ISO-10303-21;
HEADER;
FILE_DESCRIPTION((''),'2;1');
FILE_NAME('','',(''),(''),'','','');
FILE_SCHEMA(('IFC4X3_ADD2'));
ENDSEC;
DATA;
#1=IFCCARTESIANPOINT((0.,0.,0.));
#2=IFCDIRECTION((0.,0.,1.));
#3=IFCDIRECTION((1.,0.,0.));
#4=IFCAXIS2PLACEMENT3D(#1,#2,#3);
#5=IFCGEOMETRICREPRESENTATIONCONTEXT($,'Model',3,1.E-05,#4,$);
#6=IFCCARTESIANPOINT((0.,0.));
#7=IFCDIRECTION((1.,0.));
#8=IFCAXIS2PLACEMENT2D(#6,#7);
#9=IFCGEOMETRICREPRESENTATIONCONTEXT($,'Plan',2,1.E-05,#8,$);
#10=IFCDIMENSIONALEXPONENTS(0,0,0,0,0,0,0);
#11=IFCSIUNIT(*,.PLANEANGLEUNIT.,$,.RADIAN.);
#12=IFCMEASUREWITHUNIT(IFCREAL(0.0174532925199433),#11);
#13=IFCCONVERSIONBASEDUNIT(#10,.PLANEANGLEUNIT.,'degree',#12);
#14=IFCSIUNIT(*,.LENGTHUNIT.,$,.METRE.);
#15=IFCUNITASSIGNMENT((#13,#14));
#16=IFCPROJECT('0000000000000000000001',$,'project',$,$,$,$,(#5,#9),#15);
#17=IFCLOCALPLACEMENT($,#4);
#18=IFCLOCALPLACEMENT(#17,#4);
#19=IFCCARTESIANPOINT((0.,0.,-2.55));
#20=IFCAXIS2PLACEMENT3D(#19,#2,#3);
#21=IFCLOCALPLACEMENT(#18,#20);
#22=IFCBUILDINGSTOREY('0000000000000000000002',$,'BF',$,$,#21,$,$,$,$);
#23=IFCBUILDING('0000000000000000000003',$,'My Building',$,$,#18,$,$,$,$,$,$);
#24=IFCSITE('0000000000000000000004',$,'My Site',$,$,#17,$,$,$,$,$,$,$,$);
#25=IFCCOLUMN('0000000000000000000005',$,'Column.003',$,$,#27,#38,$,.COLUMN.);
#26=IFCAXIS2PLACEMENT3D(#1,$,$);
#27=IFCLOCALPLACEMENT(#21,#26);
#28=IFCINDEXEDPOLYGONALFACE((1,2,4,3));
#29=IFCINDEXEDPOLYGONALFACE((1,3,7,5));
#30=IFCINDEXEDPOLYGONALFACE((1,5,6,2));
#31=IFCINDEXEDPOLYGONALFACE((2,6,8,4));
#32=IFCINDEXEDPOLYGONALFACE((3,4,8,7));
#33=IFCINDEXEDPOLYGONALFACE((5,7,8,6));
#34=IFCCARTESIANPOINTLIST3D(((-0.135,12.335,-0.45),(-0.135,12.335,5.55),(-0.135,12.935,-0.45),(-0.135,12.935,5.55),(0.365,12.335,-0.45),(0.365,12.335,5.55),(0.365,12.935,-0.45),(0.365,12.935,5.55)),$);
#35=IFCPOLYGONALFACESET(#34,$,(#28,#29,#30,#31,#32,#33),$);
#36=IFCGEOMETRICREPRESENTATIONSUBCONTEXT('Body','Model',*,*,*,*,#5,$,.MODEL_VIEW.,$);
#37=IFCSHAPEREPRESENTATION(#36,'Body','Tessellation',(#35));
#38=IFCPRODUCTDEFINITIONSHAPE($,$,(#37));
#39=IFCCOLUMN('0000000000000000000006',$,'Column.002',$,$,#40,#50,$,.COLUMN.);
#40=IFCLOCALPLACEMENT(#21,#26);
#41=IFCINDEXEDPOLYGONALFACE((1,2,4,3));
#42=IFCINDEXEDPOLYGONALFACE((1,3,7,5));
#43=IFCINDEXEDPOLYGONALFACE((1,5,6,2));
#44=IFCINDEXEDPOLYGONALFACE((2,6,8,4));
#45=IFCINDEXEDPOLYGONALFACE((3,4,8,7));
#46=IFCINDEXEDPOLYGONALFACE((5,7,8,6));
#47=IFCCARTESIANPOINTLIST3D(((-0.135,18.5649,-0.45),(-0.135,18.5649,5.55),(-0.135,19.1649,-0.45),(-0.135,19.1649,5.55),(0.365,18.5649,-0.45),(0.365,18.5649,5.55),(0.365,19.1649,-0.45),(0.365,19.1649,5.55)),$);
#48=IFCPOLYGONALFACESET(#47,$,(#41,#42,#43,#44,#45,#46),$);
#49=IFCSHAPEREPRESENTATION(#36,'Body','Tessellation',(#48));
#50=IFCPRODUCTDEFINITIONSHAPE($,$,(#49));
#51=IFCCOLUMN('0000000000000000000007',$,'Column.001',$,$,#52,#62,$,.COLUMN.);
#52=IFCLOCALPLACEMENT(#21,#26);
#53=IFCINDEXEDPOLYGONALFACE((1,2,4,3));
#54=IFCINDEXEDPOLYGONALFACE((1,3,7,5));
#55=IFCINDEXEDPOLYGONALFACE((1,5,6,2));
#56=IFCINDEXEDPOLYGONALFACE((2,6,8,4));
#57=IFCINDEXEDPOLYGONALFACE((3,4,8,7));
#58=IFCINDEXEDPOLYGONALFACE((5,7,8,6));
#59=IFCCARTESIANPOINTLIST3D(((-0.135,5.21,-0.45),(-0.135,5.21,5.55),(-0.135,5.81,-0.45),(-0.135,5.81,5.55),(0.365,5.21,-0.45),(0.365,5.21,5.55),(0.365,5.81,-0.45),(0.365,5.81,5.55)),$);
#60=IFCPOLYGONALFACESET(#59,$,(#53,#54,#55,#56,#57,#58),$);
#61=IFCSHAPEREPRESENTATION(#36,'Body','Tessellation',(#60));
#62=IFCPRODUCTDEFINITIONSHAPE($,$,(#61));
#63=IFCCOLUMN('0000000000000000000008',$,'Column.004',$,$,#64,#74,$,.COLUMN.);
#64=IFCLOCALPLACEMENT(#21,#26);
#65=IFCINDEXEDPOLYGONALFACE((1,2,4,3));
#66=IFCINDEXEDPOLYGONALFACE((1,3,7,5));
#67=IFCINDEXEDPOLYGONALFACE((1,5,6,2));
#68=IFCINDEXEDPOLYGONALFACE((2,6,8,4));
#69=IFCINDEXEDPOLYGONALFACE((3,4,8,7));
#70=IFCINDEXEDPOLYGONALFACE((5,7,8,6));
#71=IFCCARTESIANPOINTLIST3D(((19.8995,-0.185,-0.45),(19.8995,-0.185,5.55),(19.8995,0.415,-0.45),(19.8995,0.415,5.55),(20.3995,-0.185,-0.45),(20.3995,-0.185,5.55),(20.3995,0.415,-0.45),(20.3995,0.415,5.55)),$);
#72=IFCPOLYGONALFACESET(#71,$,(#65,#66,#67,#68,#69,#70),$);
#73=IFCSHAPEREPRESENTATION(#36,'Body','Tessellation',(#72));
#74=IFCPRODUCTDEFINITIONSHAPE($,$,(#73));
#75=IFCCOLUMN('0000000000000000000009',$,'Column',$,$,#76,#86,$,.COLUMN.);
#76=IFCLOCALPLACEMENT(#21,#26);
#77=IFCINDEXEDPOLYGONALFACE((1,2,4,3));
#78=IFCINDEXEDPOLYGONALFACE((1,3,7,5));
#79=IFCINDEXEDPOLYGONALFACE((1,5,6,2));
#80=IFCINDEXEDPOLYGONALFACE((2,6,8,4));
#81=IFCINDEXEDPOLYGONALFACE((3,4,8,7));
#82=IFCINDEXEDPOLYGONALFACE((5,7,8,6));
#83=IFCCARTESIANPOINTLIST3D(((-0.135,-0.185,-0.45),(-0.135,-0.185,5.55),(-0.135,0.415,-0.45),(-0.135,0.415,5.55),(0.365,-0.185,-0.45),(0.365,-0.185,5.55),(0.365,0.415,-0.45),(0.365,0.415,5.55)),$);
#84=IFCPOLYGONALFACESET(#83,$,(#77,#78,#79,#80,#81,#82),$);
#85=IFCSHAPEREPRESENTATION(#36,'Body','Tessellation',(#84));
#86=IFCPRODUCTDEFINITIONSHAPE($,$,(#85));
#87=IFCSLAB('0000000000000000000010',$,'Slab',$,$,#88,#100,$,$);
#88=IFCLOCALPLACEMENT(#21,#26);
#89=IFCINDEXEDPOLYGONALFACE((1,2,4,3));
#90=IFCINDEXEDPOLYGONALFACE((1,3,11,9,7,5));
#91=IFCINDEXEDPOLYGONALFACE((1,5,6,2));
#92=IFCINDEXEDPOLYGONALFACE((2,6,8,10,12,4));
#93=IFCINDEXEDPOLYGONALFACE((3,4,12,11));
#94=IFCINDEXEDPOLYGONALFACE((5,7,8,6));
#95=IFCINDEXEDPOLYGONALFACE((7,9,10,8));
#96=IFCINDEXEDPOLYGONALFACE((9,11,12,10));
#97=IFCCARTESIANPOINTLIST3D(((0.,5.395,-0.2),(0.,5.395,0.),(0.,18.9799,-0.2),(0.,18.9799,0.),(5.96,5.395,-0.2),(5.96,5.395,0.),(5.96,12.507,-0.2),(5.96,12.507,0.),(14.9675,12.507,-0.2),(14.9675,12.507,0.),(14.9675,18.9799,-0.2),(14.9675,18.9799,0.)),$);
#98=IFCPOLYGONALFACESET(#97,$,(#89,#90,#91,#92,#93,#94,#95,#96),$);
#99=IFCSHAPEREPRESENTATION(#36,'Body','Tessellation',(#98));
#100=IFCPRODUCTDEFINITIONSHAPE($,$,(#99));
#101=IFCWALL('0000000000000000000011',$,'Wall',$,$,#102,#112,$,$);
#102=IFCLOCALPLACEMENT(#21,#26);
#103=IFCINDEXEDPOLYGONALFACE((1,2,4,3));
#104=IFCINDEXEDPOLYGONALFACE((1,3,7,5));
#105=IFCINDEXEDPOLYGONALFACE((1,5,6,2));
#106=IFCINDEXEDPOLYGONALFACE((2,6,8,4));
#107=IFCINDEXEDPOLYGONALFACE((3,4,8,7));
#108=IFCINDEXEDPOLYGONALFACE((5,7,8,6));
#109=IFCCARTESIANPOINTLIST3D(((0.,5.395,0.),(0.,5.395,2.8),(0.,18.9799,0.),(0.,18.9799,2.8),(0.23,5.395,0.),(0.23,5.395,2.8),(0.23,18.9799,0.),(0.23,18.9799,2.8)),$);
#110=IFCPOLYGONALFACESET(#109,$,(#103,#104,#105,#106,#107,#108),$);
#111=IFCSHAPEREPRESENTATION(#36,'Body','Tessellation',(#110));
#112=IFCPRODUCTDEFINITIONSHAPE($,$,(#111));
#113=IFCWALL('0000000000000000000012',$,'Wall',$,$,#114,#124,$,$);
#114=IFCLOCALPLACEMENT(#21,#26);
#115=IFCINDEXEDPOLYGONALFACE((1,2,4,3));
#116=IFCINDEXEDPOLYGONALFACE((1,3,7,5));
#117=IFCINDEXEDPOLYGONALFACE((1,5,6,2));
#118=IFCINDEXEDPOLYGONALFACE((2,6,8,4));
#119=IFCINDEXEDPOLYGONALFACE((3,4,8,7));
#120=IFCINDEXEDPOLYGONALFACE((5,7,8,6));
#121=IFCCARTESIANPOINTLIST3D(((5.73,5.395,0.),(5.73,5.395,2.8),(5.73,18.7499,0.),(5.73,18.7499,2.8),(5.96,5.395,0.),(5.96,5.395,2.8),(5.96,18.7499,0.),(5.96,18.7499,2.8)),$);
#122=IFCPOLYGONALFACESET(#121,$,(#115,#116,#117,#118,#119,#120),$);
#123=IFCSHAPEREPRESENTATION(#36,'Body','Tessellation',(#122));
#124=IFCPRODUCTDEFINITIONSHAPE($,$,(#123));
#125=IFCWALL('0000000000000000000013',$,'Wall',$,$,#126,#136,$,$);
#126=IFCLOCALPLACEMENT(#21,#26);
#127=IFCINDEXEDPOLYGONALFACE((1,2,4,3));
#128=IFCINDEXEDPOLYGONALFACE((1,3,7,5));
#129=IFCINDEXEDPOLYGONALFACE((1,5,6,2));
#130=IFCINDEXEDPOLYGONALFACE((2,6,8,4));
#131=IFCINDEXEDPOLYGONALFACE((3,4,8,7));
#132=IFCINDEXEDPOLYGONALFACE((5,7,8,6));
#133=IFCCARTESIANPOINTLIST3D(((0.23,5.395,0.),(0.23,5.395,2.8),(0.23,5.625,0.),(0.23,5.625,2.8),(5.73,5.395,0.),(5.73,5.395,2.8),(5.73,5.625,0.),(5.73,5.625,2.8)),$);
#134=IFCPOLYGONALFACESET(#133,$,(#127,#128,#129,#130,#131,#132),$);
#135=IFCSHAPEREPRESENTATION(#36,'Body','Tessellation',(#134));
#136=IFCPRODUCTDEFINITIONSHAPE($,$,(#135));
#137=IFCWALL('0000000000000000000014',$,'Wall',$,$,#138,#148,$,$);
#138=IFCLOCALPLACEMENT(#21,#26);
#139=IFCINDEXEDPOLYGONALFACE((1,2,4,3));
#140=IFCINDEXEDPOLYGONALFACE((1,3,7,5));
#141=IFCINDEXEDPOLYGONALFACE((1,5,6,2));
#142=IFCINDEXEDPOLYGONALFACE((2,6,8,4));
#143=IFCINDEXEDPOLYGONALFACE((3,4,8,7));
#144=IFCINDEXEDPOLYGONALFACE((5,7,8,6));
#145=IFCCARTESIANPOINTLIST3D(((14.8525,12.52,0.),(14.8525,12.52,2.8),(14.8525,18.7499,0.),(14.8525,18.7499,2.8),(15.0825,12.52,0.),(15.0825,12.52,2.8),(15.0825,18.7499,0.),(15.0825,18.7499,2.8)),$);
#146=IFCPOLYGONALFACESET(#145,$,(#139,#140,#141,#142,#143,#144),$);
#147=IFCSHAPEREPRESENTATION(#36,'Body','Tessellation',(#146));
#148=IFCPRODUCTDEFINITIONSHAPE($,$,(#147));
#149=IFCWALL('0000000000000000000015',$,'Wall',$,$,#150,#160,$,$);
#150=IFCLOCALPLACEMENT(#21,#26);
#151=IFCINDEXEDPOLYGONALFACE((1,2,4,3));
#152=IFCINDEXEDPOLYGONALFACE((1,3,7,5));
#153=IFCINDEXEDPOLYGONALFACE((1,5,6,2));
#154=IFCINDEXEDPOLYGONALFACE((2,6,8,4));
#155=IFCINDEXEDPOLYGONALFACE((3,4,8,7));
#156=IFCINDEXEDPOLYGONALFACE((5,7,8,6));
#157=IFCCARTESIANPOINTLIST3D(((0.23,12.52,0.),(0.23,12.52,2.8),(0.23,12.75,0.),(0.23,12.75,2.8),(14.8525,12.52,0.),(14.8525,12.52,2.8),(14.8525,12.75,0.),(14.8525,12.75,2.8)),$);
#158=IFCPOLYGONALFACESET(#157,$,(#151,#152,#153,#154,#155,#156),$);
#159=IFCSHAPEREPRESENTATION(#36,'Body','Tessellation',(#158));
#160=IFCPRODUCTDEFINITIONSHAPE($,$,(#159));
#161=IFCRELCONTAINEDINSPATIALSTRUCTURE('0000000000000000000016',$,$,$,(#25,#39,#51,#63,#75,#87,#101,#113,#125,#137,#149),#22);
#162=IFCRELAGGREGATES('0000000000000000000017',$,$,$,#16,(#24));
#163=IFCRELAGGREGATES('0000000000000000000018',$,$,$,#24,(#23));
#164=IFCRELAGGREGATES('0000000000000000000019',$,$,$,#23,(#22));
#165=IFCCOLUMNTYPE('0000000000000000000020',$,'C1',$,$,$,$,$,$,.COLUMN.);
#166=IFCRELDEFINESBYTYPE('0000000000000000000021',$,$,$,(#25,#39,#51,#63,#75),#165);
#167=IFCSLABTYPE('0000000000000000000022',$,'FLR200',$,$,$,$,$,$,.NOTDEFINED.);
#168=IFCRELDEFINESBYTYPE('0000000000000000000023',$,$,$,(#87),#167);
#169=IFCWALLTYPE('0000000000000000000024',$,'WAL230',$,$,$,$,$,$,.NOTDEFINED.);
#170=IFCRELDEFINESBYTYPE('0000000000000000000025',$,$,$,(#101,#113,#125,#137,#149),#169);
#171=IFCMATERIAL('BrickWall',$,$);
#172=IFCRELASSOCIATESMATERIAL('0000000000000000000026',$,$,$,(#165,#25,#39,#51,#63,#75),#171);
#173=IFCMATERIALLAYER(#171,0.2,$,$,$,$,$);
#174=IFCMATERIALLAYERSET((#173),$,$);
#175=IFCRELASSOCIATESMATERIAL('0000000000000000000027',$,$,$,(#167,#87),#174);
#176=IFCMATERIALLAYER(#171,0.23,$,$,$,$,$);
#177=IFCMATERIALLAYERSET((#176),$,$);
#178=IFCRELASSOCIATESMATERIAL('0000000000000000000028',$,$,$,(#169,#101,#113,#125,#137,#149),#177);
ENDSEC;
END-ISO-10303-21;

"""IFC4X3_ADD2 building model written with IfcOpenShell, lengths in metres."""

from ifc_helpers import new_model, entity, si_unit, converted_unit, frame, origin_with_axes, origin_2d_with_axis, place, context, subcontext, project, spatial, line, indexed_curve, rectangle, outline, extrude, material, layer, layer_set, layer_usage, material_profile, profile_set, profile_usage, type_object, element, save


model = new_model("IFC4X3_ADD2")

# Units and contexts
model_context = context("Model", 3, precision=1e-05, world=origin_with_axes())
plan_context = context("Plan", 2, precision=1e-05, world=origin_2d_with_axis())
body_context_1 = subcontext(model_context, "Body", "Model", "MODEL_VIEW")
ifc_project = project(units=[converted_unit("PLANEANGLEUNIT", "degree", entity("IfcReal", 0.0174532925199433), si_unit("PLANEANGLEUNIT", "RADIAN"), dimensions=[0, 0, 0, 0, 0, 0, 0]), si_unit("LENGTHUNIT", "METRE")], contexts=[model_context, plan_context])

# Site, building, storey
site_placement = place(None, origin_with_axes())
site = spatial("IfcSite", under=ifc_project, at=site_placement, Name="My Site")
building_placement = place(site_placement, origin_with_axes())
building = spatial("IfcBuilding", under=site, at=building_placement, Name="My Building")
storey_placement = place(building_placement, frame((0.0, 0.0, -2.55), z_axis=(0.0, 0.0, 1.0), x_axis=(1.0, 0.0, 0.0)))
storey = spatial("IfcBuildingStorey", under=building, at=storey_placement, Name="BF")

# Columns
ifc_material_1 = material(Name="BrickWall")
ifc_material_profile = material_profile(ifc_material_1, rectangle(XDim=0.5, YDim=0.6))
ifc_profile_set = profile_set([ifc_material_profile])
ifc_profile_usage_1 = profile_usage(ifc_profile_set, cardinal=5)
column_type = type_object("IfcColumnType", Name="C1", PredefinedType="COLUMN", material=ifc_profile_set)
column_1_placement = place(storey_placement, frame((0.115, 12.635, -0.45), z_axis=(0.0, 0.0, 1.0), x_axis=(1.0, 0.0, 0.0)))
element("IfcColumn", 1, at=column_1_placement, inside=storey, type_object=column_type, material=ifc_profile_usage_1, Name="Column.003", PredefinedType="COLUMN", context=body_context_1, shape_type="SweptSolid", body=[
    extrude(rectangle(XDim=0.5, YDim=0.6), origin_with_axes(), (0.0, 0.0, 1.0), 6.0),
])
ifc_profile_usage_2 = profile_usage(ifc_profile_set, cardinal=5)
column_2_placement = place(storey_placement, frame((0.115, 18.8649, -0.45), z_axis=(0.0, 0.0, 1.0), x_axis=(1.0, 0.0, 0.0)))
element("IfcColumn", 2, at=column_2_placement, inside=storey, type_object=column_type, material=ifc_profile_usage_2, Name="Column.002", PredefinedType="COLUMN", context=body_context_1, shape_type="SweptSolid", body=[
    extrude(rectangle(XDim=0.5, YDim=0.6), origin_with_axes(), (0.0, 0.0, 1.0), 6.0),
])
ifc_profile_usage_3 = profile_usage(ifc_profile_set, cardinal=5)
column_3_placement = place(storey_placement, frame((0.115, 5.51, -0.45), z_axis=(0.0, 0.0, 1.0), x_axis=(1.0, 0.0, 0.0)))
element("IfcColumn", 3, at=column_3_placement, inside=storey, type_object=column_type, material=ifc_profile_usage_3, Name="Column.001", PredefinedType="COLUMN", context=body_context_1, shape_type="SweptSolid", body=[
    extrude(rectangle(XDim=0.5, YDim=0.6), origin_with_axes(), (0.0, 0.0, 1.0), 6.0),
])
ifc_profile_usage_4 = profile_usage(ifc_profile_set, cardinal=5)
column_4_placement = place(storey_placement, frame((20.1495, 0.115, -0.45), z_axis=(0.0, 0.0, 1.0), x_axis=(1.0, 0.0, 0.0)))
element("IfcColumn", 4, at=column_4_placement, inside=storey, type_object=column_type, material=ifc_profile_usage_4, Name="Column.004", PredefinedType="COLUMN", context=body_context_1, shape_type="SweptSolid", body=[
    extrude(rectangle(XDim=0.5, YDim=0.6), origin_with_axes(), (0.0, 0.0, 1.0), 6.0),
])
ifc_profile_usage_5 = profile_usage(ifc_profile_set, cardinal=5)
column_5_placement = place(storey_placement, frame((0.115, 0.115, -0.45), z_axis=(0.0, 0.0, 1.0), x_axis=(1.0, 0.0, 0.0)))
element("IfcColumn", 5, at=column_5_placement, inside=storey, type_object=column_type, material=ifc_profile_usage_5, Name="Column", PredefinedType="COLUMN", context=body_context_1, shape_type="SweptSolid", body=[
    extrude(rectangle(XDim=0.5, YDim=0.6), origin_with_axes(), (0.0, 0.0, 1.0), 6.0),
])

# Slab
ifc_layer_1 = layer(ifc_material_1, 0.2)
ifc_layer_set_1 = layer_set([ifc_layer_1])
ifc_layer_usage_1 = layer_usage(ifc_layer_set_1, "AXIS3", "POSITIVE", 0.0)
slab_type = type_object("IfcSlabType", Name="FLR200", PredefinedType="NOTDEFINED", material=ifc_layer_set_1)
slab_placement = place(storey_placement, frame((0.0, 5.395, -0.2), z_axis=(0.0, 0.0, 1.0), x_axis=(1.0, 0.0, 0.0)))
element("IfcSlab", 6, at=slab_placement, inside=storey, type_object=slab_type, material=ifc_layer_usage_1, Name="Slab", context=body_context_1, shape_type="SweptSolid", body=[
    extrude(outline(indexed_curve([(5.96, 0.0), (0.0, 0.0), (0.0, 13.5849), (14.9675, 13.5849), (14.9675, 7.112), (5.96, 7.112)], segments=[line(1, 2), line(2, 3), line(3, 4), line(4, 5), line(5, 6), line(6, 1)], self_intersect=False)), None, (0.0, 0.0, 1.0), 0.2),
])

# Shared definitions
ifc_layer_2 = layer(ifc_material_1, 0.23)
ifc_layer_set_2 = layer_set([ifc_layer_2])
wall_type = type_object("IfcWallType", Name="WAL230", PredefinedType="NOTDEFINED", material=ifc_layer_set_2)

# Walls
ifc_layer_usage_2 = layer_usage(ifc_layer_set_2, "AXIS2", "POSITIVE", 0.0)
wall_1_placement = place(storey_placement, frame((0.23, 5.395, 0.0), z_axis=(0.0, 0.0, 1.0), x_axis=(0.0, 1.0, 0.0)))
element("IfcWall", 7, at=wall_1_placement, inside=storey, type_object=wall_type, material=ifc_layer_usage_2, Name="Wall", context=body_context_1, shape_type="SweptSolid", body=[
    extrude(outline(indexed_curve([(0.0, 0.0), (0.0, 0.23), (13.5849, 0.23), (13.5849, 0.0), (0.0, 0.0)], self_intersect=False)), origin_with_axes(), (0.0, 0.0, 1.0), 2.8),
])
ifc_layer_usage_3 = layer_usage(ifc_layer_set_2, "AXIS2", "POSITIVE", 0.0)
wall_2_placement = place(storey_placement, frame((5.96, 5.395, 0.0), z_axis=(0.0, 0.0, 1.0), x_axis=(0.0, 1.0, 0.0)))
element("IfcWall", 8, at=wall_2_placement, inside=storey, type_object=wall_type, material=ifc_layer_usage_3, Name="Wall", context=body_context_1, shape_type="SweptSolid", body=[
    extrude(outline(indexed_curve([(0.0, 0.0), (0.0, 0.23), (13.3549, 0.23), (13.3549, 0.0), (0.0, 0.0)], self_intersect=False)), origin_with_axes(), (0.0, 0.0, 1.0), 2.8),
])
ifc_layer_usage_4 = layer_usage(ifc_layer_set_2, "AXIS2", "POSITIVE", 0.0)
wall_3_placement = place(storey_placement, frame((0.23, 5.395, 0.0), z_axis=(0.0, 0.0, 1.0), x_axis=(1.0, 0.0, 0.0)))
element("IfcWall", 9, at=wall_3_placement, inside=storey, type_object=wall_type, material=ifc_layer_usage_4, Name="Wall", context=body_context_1, shape_type="SweptSolid", body=[
    extrude(outline(indexed_curve([(0.0, 0.0), (0.0, 0.23), (5.5, 0.23), (5.5, 0.0), (0.0, 0.0)], self_intersect=False)), origin_with_axes(), (0.0, 0.0, 1.0), 2.8),
])
ifc_layer_usage_5 = layer_usage(ifc_layer_set_2, "AXIS2", "POSITIVE", 0.0)
wall_4_placement = place(storey_placement, frame((15.0825, 12.52, 0.0), z_axis=(0.0, 0.0, 1.0), x_axis=(0.0, 1.0, 0.0)))
element("IfcWall", 10, at=wall_4_placement, inside=storey, type_object=wall_type, material=ifc_layer_usage_5, Name="Wall", context=body_context_1, shape_type="SweptSolid", body=[
    extrude(outline(indexed_curve([(0.0, 0.0), (0.0, 0.23), (6.2299, 0.23), (6.2299, 0.0), (0.0, 0.0)], self_intersect=False)), origin_with_axes(), (0.0, 0.0, 1.0), 2.8),
])
ifc_layer_usage_6 = layer_usage(ifc_layer_set_2, "AXIS2", "POSITIVE", 0.0)
wall_5_placement = place(storey_placement, frame((0.23, 12.52, 0.0), z_axis=(0.0, 0.0, 1.0), x_axis=(1.0, 0.0, 0.0)))
element("IfcWall", 11, at=wall_5_placement, inside=storey, type_object=wall_type, material=ifc_layer_usage_6, Name="Wall", context=body_context_1, shape_type="SweptSolid", body=[
    extrude(outline(indexed_curve([(0.0, 0.0), (0.0, 0.23), (14.6225, 0.23), (14.6225, 0.0), (0.0, 0.0)], self_intersect=False)), origin_with_axes(), (0.0, 0.0, 1.0), 2.8),
])

save(model, "model.ifc")
